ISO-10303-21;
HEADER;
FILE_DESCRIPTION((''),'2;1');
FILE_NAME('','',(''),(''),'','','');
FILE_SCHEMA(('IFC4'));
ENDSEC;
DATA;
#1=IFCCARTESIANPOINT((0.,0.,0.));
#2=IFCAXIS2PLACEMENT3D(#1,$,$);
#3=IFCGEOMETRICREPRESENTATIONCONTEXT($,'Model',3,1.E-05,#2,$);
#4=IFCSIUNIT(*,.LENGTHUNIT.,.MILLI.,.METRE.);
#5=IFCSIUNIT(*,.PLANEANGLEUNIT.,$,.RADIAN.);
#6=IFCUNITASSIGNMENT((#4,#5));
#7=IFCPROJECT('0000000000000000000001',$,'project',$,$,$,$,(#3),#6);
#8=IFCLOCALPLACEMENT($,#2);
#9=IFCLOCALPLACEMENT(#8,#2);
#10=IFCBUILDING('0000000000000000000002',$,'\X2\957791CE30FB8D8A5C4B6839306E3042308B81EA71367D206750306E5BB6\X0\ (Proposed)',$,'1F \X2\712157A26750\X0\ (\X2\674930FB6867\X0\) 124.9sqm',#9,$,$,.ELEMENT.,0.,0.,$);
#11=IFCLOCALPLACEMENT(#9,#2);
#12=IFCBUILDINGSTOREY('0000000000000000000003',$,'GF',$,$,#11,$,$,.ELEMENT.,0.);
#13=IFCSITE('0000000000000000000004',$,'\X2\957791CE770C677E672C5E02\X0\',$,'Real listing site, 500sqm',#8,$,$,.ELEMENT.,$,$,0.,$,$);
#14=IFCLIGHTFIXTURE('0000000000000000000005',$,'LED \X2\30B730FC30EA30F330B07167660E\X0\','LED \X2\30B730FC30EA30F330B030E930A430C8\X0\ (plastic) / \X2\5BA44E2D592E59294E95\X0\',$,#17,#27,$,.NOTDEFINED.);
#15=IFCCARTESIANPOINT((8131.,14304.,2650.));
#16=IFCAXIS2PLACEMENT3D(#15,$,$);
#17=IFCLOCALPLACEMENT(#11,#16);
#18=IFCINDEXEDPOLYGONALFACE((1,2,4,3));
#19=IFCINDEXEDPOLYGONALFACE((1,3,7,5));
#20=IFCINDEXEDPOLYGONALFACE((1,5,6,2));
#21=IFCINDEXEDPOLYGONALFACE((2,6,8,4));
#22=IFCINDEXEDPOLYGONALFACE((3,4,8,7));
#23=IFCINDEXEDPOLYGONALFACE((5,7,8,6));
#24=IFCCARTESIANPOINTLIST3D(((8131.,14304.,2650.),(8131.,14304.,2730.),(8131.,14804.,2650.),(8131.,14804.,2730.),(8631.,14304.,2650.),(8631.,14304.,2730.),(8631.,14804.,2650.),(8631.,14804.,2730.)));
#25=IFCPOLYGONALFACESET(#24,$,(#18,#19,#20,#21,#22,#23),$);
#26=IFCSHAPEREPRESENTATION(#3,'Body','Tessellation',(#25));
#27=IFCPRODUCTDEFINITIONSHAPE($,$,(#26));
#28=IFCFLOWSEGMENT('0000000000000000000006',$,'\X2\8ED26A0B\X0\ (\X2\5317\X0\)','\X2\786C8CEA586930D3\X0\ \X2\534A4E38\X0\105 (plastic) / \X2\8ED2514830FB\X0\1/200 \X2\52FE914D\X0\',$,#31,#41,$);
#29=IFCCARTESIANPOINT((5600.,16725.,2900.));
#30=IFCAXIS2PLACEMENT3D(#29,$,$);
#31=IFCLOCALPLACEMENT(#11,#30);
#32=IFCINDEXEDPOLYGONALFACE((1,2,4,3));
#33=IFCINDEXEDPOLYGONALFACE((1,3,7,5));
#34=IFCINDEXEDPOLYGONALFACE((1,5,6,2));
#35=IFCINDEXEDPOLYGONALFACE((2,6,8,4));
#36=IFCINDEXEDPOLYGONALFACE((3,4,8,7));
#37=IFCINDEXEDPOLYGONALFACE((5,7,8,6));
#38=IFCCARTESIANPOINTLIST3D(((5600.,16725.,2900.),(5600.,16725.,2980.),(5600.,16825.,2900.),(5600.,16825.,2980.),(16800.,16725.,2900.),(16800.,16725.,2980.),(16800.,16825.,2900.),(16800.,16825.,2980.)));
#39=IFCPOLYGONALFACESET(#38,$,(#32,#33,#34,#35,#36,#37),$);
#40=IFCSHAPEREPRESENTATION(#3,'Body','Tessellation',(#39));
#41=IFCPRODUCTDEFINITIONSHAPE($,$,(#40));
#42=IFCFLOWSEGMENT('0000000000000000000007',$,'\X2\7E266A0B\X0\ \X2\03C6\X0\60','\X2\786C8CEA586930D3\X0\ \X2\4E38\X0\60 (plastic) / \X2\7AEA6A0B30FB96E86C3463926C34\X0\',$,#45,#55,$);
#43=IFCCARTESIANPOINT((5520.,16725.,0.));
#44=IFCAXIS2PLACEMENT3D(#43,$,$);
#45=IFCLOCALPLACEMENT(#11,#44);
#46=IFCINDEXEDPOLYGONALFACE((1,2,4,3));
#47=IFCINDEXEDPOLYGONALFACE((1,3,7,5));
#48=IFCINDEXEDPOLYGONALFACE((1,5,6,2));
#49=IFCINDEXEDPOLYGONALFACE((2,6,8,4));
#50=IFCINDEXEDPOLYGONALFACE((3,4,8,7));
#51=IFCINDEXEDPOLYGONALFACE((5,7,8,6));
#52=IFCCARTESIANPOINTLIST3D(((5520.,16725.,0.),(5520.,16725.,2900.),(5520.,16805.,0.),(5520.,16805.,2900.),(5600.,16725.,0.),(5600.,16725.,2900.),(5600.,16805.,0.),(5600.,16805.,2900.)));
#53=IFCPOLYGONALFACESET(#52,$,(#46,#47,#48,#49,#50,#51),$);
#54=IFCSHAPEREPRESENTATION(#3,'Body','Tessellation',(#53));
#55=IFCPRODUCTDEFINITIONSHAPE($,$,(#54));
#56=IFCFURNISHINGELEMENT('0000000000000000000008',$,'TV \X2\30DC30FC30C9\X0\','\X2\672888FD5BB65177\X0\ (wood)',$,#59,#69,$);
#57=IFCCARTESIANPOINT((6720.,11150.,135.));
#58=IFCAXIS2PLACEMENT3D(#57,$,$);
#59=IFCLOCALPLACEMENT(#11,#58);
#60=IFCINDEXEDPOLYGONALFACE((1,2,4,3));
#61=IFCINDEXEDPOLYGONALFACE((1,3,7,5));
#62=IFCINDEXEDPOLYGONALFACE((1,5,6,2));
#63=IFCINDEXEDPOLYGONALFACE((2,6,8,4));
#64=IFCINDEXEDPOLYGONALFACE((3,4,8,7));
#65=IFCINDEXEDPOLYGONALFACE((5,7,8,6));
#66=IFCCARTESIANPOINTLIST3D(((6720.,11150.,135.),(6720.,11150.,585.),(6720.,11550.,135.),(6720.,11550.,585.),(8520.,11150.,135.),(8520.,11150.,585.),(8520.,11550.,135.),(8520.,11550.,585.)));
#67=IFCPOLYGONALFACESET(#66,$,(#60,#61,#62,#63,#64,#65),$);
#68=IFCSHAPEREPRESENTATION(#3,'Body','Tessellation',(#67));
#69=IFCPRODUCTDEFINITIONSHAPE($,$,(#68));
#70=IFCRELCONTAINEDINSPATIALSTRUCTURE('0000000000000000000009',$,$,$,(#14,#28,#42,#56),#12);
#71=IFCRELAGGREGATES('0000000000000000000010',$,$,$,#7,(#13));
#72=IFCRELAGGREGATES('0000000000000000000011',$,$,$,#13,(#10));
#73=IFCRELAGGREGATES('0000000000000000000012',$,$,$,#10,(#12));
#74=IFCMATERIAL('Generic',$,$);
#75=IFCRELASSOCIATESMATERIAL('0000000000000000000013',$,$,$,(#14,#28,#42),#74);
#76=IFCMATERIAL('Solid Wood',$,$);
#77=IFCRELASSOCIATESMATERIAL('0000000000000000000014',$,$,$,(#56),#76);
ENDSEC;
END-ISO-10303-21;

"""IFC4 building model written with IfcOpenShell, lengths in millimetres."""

from ifc_helpers import new_model, si_unit, frame, frame_2d, origin, place, context, project, spatial, rectangle, extrude, material, element, save


model = new_model("IFC4")

# Units and contexts
model_context = context("Model", 3, precision=1e-05, world=origin())
ifc_project = project(units=[si_unit("LENGTHUNIT", "METRE", prefix="MILLI"), si_unit("PLANEANGLEUNIT", "RADIAN")], contexts=[model_context])

# Site, building, storey
site_placement = place(None, origin())
site = spatial("IfcSite", under=ifc_project, at=site_placement, Name="長野県松本市", ObjectType="Real listing site, 500sqm", CompositionType="ELEMENT", RefElevation=0.0)
building_placement = place(site_placement, origin())
building = spatial("IfcBuilding", under=site, at=building_placement, Name="長野・越屋根のある自然素材の家 (Proposed)", ObjectType="1F 無垢材 (杉・桧) 124.9sqm", CompositionType="ELEMENT", ElevationOfRefHeight=0.0, ElevationOfTerrain=0.0)
storey_placement = place(building_placement, origin())
storey = spatial("IfcBuildingStorey", under=building, at=storey_placement, Name="GF", CompositionType="ELEMENT", Elevation=0.0)

# Shared definitions
ifc_material_1 = material(Name="Solid Wood")

# Shared definitions
ifc_material_2 = material(Name="Generic")

# Light fixture
light_fixture_placement = place(storey_placement, frame((8131.0, 14304.0, 2650.0)))
element("IfcLightFixture", 1, at=light_fixture_placement, inside=storey, material=ifc_material_2, Name="LED シーリング照明", Description="LED シーリングライト (plastic) / 室中央天井", PredefinedType="NOTDEFINED", context=model_context, shape_type="SweptSolid", body=[
    extrude(rectangle(XDim=500.0, YDim=500.0, at=frame_2d((250.0, 250.0))), frame((8131.0, 14304.0, 2650.0)), (0.0, 0.0, 1.0), 80.0),
])

# Flow segments
flow_segment_1_placement = place(storey_placement, frame((5600.0, 16725.0, 2900.0)))
element("IfcFlowSegment", 2, at=flow_segment_1_placement, inside=storey, material=ifc_material_2, Name="軒樋 (北)", Description="硬質塩ビ 半丸105 (plastic) / 軒先・1/200 勾配", context=model_context, shape_type="SweptSolid", body=[
    extrude(rectangle(XDim=11200.0, YDim=100.0, at=frame_2d((5600.0, 50.0))), frame((5600.0, 16725.0, 2900.0)), (0.0, 0.0, 1.0), 80.0),
])
flow_segment_2_placement = place(storey_placement, frame((5520.0, 16725.0, 0.0)))
element("IfcFlowSegment", 3, at=flow_segment_2_placement, inside=storey, material=ifc_material_2, Name="縦樋 φ60", Description="硬質塩ビ 丸60 (plastic) / 竪樋・雨水排水", context=model_context, shape_type="SweptSolid", body=[
    extrude(rectangle(XDim=80.0, YDim=80.0, at=frame_2d((40.0, 40.0))), frame((5520.0, 16725.0, 0.0)), (0.0, 0.0, 1.0), 2900.0),
])

# Furnishing element
furnishing_placement = place(storey_placement, frame((6720.0, 11150.0, 135.0)))
element("IfcFurnishingElement", 4, at=furnishing_placement, inside=storey, material=ifc_material_1, Name="TV ボード", Description="木製家具 (wood)", context=model_context, shape_type="SweptSolid", body=[
    extrude(rectangle(XDim=1800.0, YDim=400.0, at=frame_2d((900.0, 200.0))), frame((6720.0, 11150.0, 135.0)), (0.0, 0.0, 1.0), 450.0),
])

save(model, "model.ifc")
